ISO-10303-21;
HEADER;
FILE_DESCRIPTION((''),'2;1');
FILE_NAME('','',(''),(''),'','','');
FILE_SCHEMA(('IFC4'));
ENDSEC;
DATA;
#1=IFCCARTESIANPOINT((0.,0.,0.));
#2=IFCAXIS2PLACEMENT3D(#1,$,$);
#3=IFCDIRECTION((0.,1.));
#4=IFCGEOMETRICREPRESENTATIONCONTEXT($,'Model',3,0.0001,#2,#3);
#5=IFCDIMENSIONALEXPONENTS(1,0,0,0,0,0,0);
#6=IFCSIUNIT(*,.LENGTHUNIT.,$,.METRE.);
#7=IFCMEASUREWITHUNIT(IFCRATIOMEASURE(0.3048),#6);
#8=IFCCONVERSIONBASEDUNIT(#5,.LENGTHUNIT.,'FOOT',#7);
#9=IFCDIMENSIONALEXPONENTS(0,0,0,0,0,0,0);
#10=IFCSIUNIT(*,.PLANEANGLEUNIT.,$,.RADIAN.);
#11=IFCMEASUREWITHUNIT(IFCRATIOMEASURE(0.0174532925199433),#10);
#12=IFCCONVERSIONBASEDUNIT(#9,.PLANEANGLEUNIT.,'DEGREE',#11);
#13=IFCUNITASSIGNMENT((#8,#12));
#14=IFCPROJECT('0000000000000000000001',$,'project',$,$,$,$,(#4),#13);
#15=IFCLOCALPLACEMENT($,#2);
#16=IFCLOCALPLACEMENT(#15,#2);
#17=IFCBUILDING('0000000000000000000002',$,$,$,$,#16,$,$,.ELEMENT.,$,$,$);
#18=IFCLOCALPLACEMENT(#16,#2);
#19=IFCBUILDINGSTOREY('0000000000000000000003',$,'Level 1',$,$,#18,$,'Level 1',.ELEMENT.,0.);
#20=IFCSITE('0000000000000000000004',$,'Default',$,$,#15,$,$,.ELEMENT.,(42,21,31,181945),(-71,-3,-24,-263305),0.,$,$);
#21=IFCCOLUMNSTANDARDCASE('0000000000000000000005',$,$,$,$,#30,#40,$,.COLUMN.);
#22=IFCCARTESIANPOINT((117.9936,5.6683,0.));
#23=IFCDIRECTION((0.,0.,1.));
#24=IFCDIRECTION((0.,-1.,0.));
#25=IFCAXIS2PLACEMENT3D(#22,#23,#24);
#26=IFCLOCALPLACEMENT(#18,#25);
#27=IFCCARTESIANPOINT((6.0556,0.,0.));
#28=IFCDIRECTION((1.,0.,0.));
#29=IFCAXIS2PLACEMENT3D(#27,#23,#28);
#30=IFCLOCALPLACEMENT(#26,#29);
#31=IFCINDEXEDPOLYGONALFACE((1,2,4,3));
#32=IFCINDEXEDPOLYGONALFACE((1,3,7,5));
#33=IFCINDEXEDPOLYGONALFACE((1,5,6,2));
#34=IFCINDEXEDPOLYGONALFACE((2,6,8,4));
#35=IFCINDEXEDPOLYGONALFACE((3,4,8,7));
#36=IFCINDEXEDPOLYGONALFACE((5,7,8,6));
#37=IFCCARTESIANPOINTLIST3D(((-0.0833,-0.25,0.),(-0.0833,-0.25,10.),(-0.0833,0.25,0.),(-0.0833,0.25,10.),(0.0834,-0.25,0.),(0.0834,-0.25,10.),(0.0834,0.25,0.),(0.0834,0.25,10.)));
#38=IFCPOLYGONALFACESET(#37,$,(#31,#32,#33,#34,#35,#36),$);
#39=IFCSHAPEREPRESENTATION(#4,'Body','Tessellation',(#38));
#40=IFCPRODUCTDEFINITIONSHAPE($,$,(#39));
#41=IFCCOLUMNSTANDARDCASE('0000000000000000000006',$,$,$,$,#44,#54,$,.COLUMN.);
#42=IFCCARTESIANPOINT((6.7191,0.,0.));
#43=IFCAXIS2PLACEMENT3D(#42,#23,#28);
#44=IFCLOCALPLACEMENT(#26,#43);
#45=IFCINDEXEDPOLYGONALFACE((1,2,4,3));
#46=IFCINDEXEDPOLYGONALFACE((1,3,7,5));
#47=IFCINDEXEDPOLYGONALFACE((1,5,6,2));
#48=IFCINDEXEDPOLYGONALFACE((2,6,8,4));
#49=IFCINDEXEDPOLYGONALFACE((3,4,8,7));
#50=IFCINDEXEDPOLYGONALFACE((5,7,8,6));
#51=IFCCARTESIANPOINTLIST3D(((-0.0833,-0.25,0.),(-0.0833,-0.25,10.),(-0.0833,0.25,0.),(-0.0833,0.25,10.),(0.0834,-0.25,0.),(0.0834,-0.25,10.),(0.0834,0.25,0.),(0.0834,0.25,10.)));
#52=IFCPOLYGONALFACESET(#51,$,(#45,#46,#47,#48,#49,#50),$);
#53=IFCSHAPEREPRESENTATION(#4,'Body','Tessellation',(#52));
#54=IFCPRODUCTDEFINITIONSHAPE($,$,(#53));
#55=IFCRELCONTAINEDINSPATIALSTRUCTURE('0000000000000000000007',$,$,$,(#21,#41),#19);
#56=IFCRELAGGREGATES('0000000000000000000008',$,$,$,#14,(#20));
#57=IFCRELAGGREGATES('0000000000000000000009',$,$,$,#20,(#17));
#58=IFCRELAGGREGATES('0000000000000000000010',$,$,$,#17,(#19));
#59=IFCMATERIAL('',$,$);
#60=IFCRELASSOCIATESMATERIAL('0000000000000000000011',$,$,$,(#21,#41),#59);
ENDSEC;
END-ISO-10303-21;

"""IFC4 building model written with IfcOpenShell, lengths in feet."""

from ifc_helpers import new_model, entity, si_unit, converted_unit, direction, frame, origin, place, context, project, spatial, rectangle, extrude, material, element, save


model = new_model("IFC4")

# Units and contexts
model_context = context("Model", 3, precision=0.0001, world=origin(), true_north=direction((0.0, 1.0)))
ifc_project = project(units=[converted_unit("LENGTHUNIT", "FOOT", entity("IfcRatioMeasure", 0.3048), si_unit("LENGTHUNIT", "METRE"), dimensions=[1, 0, 0, 0, 0, 0, 0]), converted_unit("PLANEANGLEUNIT", "DEGREE", entity("IfcRatioMeasure", 0.0174532925199433), si_unit("PLANEANGLEUNIT", "RADIAN"), dimensions=[0, 0, 0, 0, 0, 0, 0])], contexts=[model_context])

# Site, building, storey
site_placement = place(None, origin())
site = spatial("IfcSite", under=ifc_project, at=site_placement, Name="Default", CompositionType="ELEMENT", RefLatitude=(42, 21, 31, 181945), RefLongitude=(-71, -3, -24, -263305), RefElevation=0.0)
building_placement = place(site_placement, origin())
building = spatial("IfcBuilding", under=site, at=building_placement, CompositionType="ELEMENT")
storey_placement = place(building_placement, origin())
storey = spatial("IfcBuildingStorey", under=building, at=storey_placement, Name="Level 1", LongName="Level 1", CompositionType="ELEMENT", Elevation=0.0)

# Columns
ifc_material_1 = material(Name="")
wall_placement = place(storey_placement, frame((117.9936, 5.6683, 0.0), z_axis=(0.0, 0.0, 1.0), x_axis=(0.0, -1.0, 0.0)))
for number, where, z_axis, x_axis in (
    (1, (6.0556, 0.0, 0.0), (0.0, 0.0, 1.0), (1.0, 0.0, 0.0)),
    (2, (6.7191, 0.0, 0.0), (0.0, 0.0, 1.0), (1.0, 0.0, 0.0)),
):
    element("IfcColumnStandardCase", number, at=place(wall_placement, frame(where, z_axis=z_axis, x_axis=x_axis)), inside=storey, material=ifc_material_1, PredefinedType="COLUMN", context=model_context, shape_type="SweptSolid", body=[
        extrude(rectangle(XDim=0.1667, YDim=0.5), origin(), (0.0, 0.0, 1.0), 10.0),
    ])

save(model, "model.ifc")
